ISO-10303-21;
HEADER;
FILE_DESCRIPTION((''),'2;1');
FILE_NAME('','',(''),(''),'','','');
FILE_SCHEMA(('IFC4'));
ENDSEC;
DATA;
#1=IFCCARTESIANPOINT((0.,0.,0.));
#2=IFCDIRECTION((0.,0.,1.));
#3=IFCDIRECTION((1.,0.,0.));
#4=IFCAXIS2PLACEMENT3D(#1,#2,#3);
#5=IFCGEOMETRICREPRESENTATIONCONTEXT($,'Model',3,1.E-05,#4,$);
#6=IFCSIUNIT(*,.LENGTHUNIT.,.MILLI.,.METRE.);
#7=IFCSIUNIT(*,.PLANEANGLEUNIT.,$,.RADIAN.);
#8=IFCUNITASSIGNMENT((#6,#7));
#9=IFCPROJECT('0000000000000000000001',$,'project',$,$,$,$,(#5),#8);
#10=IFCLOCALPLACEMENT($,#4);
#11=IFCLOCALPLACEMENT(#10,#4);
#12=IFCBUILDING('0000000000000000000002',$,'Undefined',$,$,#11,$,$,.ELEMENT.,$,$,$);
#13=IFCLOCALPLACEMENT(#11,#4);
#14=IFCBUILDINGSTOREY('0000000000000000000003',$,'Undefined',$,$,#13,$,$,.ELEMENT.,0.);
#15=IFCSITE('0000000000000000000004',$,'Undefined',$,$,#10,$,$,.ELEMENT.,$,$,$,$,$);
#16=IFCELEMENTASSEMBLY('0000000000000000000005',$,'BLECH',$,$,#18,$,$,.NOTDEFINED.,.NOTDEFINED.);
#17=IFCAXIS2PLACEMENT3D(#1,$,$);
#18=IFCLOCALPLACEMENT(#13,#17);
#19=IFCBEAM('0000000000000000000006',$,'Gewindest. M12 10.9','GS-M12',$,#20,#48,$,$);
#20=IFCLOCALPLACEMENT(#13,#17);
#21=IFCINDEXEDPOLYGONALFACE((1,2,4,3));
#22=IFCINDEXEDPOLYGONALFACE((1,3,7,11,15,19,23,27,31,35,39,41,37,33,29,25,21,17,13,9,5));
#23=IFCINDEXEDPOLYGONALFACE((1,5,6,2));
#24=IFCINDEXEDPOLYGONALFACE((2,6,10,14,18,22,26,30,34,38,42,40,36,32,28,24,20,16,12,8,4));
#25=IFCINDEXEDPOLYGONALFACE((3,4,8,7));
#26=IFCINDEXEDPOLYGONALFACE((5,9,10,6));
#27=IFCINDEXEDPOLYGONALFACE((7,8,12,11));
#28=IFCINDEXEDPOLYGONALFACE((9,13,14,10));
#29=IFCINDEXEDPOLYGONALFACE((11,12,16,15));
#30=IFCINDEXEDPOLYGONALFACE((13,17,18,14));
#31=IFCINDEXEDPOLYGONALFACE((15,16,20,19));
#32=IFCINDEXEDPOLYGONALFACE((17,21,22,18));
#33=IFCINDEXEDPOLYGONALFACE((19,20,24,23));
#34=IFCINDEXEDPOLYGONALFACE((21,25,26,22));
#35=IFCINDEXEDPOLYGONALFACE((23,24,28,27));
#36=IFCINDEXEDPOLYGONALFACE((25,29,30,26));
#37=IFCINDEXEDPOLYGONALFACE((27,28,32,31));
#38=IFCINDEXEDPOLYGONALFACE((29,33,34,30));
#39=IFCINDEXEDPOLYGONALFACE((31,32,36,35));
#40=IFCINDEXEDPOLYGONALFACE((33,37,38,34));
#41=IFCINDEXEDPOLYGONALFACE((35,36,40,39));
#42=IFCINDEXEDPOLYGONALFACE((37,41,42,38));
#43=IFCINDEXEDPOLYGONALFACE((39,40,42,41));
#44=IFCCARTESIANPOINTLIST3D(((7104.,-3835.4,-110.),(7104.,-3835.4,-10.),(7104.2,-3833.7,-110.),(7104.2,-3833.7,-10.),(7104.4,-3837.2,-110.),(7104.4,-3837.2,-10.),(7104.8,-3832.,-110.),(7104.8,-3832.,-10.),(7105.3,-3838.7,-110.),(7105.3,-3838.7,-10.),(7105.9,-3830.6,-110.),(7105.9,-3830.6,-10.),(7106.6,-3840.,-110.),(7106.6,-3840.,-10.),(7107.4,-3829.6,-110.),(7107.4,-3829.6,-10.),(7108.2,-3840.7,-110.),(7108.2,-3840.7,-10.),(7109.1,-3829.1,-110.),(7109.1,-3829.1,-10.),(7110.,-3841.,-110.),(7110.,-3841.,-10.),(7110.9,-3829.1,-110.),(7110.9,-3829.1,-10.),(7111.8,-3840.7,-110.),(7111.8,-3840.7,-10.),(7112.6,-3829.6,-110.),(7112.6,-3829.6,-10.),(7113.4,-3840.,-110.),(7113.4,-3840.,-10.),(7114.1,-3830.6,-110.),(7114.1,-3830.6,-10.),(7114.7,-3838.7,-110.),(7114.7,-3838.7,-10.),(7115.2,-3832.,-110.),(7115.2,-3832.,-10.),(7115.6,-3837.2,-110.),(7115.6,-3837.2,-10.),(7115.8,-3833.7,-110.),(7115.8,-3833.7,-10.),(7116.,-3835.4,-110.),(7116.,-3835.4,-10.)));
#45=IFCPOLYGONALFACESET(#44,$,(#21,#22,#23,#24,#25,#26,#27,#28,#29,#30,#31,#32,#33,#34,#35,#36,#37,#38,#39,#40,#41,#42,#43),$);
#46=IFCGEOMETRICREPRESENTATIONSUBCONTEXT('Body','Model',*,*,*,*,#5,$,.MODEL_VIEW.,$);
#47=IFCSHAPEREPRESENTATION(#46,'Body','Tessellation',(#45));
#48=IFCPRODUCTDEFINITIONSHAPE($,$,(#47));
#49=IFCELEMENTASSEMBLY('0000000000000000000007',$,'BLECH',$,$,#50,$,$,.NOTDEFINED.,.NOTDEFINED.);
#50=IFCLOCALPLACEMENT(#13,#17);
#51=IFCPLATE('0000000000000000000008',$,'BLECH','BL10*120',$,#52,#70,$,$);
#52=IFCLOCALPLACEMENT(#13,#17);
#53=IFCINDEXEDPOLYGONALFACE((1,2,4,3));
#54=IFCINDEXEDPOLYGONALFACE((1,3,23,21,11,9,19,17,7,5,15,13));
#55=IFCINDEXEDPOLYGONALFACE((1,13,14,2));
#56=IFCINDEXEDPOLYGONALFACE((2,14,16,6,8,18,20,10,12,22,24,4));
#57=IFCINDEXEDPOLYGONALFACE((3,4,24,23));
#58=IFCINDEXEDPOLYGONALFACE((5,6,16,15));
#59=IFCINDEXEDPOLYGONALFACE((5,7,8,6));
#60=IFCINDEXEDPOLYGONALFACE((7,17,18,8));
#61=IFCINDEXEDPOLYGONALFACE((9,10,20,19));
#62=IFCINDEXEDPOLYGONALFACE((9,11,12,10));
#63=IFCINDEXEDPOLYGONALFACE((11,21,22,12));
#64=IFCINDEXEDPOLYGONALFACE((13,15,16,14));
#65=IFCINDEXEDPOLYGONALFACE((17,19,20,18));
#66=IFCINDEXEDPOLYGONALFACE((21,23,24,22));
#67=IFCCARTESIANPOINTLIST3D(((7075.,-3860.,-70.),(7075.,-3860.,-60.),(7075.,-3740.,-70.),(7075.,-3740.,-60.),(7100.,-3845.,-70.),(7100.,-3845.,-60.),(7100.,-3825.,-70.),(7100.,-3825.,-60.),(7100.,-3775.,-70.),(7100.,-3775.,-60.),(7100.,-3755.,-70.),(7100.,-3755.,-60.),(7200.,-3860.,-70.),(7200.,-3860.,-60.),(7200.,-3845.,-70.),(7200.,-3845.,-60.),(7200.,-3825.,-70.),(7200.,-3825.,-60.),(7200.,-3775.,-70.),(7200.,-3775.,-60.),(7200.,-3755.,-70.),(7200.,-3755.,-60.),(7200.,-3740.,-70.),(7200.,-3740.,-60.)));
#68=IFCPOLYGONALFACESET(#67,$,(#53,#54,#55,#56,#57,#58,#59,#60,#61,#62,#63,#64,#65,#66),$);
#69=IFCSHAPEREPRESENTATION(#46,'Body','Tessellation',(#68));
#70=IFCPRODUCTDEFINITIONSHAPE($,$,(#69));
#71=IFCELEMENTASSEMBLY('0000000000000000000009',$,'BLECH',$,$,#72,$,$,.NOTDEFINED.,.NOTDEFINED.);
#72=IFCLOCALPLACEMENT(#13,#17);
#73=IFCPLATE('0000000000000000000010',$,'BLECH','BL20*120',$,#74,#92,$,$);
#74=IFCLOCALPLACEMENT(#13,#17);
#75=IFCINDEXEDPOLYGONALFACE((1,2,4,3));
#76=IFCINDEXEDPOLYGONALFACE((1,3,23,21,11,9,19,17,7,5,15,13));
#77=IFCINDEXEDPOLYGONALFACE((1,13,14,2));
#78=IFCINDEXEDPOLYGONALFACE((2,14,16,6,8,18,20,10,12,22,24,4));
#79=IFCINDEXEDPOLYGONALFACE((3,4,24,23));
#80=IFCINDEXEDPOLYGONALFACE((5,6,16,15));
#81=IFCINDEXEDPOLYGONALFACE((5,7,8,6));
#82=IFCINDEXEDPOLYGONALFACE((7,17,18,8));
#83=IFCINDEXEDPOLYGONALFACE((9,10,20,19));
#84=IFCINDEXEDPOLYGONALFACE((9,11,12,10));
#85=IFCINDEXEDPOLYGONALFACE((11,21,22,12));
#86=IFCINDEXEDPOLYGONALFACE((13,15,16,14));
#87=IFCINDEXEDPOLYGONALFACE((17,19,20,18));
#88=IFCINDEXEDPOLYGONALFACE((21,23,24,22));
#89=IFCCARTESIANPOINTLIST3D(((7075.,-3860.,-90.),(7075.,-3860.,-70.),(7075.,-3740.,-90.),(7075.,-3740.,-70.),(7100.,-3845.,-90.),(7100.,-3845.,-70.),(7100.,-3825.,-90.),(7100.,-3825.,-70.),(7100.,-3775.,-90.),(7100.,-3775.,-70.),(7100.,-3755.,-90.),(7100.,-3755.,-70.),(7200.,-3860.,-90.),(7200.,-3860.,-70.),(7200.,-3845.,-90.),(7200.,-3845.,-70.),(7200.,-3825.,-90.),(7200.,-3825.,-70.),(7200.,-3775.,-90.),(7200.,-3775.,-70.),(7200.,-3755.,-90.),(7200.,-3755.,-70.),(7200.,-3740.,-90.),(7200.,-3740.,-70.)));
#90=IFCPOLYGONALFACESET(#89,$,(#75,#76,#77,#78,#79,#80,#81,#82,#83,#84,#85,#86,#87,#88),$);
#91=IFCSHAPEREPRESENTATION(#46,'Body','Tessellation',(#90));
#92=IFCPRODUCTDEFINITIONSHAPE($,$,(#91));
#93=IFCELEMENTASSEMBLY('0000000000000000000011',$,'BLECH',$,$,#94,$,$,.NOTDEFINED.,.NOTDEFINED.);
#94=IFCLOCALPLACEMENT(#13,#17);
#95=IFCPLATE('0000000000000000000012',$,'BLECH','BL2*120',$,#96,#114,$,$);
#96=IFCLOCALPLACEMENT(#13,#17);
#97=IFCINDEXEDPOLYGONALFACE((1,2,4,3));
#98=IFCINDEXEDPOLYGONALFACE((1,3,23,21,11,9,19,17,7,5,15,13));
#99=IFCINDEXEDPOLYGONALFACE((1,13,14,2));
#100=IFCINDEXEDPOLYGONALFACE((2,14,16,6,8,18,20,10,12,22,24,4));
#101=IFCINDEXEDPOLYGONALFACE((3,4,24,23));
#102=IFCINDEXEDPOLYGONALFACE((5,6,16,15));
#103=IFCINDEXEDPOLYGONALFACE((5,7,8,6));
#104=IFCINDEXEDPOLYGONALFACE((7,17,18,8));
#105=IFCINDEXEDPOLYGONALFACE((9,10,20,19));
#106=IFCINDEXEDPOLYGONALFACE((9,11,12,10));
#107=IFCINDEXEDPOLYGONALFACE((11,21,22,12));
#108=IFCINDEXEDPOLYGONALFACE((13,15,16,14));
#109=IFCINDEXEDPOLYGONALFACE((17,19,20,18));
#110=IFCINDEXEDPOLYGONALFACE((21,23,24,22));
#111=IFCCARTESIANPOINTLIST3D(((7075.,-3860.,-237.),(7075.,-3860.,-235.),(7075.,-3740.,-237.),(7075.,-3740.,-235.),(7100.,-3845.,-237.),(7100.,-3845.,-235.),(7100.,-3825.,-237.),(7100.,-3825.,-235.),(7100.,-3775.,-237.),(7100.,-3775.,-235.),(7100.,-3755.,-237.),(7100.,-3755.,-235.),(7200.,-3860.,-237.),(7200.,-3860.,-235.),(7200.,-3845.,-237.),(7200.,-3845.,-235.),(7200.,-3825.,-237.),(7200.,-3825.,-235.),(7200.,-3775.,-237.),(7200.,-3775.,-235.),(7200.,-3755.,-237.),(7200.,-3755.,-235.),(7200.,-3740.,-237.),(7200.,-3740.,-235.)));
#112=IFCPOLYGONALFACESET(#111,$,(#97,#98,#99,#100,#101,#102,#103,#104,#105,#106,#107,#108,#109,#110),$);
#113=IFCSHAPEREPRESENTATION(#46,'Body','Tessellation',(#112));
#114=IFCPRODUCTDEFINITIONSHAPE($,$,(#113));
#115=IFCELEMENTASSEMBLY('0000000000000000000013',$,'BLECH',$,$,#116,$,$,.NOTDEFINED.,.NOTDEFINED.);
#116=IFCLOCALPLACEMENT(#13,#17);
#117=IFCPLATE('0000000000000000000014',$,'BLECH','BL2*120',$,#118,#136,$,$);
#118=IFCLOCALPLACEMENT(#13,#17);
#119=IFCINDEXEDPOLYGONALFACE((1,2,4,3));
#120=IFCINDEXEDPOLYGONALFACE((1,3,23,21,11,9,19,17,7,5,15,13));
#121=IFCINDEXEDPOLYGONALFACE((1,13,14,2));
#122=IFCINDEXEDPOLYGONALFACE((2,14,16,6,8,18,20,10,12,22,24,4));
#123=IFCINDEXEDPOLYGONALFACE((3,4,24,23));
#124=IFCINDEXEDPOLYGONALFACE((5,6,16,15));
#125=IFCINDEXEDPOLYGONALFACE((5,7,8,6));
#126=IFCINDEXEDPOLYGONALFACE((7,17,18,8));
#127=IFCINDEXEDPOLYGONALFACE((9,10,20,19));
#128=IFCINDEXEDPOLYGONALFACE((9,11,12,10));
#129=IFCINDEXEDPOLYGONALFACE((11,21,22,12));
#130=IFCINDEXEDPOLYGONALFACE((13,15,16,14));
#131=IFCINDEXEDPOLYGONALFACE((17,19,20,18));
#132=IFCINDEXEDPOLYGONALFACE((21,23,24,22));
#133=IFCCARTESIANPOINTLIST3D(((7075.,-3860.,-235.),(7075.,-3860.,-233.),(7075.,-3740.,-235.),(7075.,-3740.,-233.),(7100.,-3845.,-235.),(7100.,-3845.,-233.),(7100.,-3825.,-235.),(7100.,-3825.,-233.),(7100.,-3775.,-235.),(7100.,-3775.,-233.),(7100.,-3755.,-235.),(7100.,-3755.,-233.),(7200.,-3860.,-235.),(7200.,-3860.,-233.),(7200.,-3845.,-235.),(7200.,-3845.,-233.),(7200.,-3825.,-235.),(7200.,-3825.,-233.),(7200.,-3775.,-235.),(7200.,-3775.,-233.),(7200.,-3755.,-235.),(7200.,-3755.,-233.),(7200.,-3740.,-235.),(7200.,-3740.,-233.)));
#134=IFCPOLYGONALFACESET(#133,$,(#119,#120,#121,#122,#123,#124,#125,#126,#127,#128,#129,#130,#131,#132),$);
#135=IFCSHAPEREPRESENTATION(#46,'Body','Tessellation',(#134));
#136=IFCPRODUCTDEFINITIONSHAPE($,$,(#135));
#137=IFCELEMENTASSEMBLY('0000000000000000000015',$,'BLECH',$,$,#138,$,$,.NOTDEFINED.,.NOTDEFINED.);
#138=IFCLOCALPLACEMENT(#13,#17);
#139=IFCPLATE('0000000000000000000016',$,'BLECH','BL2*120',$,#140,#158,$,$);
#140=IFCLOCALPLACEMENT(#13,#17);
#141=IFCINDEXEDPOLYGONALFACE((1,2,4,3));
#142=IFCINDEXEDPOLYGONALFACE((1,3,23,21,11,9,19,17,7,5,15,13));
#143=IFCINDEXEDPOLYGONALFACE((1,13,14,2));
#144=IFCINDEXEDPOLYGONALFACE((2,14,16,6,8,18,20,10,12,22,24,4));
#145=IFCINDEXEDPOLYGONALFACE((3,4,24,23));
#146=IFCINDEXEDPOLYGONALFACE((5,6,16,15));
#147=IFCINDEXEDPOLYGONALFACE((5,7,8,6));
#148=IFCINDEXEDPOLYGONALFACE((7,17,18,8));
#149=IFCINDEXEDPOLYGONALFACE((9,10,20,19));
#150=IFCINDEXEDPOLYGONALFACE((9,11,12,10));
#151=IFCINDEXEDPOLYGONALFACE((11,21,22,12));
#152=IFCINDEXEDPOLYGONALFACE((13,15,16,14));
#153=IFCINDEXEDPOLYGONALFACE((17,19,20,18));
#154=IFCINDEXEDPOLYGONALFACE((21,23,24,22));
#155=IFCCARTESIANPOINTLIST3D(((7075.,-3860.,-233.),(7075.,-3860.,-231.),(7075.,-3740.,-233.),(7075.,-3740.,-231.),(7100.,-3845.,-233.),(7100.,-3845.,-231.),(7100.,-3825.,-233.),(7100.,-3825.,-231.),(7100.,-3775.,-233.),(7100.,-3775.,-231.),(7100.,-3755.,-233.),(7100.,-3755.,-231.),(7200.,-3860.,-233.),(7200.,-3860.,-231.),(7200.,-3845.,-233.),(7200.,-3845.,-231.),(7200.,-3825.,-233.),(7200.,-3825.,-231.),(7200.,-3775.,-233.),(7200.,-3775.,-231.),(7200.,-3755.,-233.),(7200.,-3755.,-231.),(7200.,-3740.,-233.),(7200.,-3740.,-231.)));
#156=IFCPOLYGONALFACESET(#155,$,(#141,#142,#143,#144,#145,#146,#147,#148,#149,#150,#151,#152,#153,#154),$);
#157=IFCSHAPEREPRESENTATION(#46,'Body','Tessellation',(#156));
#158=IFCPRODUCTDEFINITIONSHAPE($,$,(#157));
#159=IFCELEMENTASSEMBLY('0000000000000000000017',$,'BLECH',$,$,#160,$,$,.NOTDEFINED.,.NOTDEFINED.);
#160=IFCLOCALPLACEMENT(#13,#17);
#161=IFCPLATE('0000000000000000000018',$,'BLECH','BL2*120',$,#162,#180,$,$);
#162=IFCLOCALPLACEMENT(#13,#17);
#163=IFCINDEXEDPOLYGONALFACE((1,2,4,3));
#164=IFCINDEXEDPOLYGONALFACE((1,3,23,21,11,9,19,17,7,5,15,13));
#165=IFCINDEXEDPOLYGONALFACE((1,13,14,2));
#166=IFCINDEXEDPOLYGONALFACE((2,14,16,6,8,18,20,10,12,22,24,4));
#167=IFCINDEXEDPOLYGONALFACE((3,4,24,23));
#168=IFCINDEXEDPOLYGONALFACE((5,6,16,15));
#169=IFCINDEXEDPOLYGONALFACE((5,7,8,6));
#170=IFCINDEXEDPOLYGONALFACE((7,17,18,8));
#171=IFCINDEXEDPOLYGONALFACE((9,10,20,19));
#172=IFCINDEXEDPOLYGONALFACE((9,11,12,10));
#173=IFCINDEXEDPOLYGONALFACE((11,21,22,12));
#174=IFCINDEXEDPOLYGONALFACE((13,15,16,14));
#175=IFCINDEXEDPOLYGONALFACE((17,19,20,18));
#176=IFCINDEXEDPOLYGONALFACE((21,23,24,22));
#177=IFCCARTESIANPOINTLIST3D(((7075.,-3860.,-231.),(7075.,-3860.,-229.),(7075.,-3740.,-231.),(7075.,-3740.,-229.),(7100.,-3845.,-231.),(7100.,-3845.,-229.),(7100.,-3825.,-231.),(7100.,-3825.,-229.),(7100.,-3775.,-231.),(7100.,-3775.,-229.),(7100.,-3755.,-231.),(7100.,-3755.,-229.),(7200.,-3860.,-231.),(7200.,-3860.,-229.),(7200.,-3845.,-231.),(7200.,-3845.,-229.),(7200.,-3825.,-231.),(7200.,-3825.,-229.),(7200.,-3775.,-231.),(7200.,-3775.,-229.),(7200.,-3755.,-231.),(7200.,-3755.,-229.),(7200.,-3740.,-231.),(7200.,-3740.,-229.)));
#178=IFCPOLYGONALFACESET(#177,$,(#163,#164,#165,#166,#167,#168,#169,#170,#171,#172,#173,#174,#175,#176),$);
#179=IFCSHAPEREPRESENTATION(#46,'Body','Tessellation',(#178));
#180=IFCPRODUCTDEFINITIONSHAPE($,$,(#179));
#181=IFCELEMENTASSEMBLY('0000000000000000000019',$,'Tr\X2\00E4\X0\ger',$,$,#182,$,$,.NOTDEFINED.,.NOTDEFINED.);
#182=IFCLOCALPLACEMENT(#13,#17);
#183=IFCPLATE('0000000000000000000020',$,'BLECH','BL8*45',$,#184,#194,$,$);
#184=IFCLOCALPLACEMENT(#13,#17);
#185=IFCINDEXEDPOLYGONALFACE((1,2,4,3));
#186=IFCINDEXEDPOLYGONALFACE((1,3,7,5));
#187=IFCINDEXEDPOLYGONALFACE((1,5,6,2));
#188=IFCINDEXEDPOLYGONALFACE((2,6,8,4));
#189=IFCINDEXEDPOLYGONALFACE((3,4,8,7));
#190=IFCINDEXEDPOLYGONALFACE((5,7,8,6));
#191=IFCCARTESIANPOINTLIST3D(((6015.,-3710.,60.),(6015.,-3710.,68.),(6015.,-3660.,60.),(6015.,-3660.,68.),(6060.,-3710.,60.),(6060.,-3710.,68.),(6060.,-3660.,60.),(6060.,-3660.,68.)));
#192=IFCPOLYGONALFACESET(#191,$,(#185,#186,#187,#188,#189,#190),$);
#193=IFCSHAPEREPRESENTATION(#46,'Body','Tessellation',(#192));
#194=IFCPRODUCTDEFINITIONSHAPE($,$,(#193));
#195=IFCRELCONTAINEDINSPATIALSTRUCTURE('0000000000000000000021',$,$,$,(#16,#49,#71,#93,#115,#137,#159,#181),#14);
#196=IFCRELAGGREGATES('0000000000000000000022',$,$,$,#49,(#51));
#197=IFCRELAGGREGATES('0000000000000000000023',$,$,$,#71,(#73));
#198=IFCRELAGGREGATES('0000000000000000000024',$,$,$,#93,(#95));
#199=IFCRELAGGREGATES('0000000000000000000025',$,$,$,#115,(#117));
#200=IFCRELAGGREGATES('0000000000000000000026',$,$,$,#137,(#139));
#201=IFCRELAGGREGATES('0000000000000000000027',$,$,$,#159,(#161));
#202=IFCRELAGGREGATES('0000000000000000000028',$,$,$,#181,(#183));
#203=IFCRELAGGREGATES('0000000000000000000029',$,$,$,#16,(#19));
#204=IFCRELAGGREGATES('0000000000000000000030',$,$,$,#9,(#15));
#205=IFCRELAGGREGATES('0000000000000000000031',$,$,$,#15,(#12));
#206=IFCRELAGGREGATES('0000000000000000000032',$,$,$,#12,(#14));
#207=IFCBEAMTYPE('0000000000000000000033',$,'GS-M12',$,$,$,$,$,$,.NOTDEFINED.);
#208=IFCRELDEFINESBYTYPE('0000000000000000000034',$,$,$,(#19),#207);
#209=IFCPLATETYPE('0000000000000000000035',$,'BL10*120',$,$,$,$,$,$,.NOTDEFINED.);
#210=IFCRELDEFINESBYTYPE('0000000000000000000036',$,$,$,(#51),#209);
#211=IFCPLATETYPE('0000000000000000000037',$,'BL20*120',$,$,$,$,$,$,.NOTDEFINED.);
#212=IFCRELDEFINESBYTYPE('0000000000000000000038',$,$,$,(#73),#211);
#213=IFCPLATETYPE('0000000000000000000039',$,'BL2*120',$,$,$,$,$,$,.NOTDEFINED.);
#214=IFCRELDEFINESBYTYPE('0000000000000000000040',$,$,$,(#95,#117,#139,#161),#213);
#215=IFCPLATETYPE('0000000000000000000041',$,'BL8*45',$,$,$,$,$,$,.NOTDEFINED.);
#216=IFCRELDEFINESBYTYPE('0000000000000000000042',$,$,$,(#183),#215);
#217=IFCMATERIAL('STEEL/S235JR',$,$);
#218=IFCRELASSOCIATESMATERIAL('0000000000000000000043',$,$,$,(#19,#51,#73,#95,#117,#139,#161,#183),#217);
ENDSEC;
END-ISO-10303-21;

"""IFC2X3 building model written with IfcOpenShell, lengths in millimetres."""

from ifc_helpers import new_model, si_unit, frame, origin_with_axes, origin_2d_with_axis, place, context, subcontext, project, spatial, polyline, circle, outline, extrude, material, type_object, element, aggregate, save


model = new_model("IFC2X3")

# Units and contexts
model_context = context("Model", 3, precision=1e-05, world=origin_with_axes())
body_context = subcontext(model_context, "Body", "Model", "MODEL_VIEW")
ifc_project = project(units=[si_unit("LENGTHUNIT", "METRE", prefix="MILLI"), si_unit("PLANEANGLEUNIT", "RADIAN")], contexts=[model_context])

# Site, building, storey
site_placement = place(None, origin_with_axes())
site = spatial("IfcSite", under=ifc_project, at=site_placement, Name="Undefined", CompositionType="ELEMENT")
building_placement = place(site_placement, origin_with_axes())
building = spatial("IfcBuilding", under=site, at=building_placement, Name="Undefined", CompositionType="ELEMENT")
storey_placement = place(building_placement, origin_with_axes())
storey = spatial("IfcBuildingStorey", under=building, at=storey_placement, Name="Undefined", CompositionType="ELEMENT", Elevation=0.0)

# Element assembly, beam
assembly_1_placement = place(storey_placement, origin_with_axes())
assembly_1 = element("IfcElementAssembly", 1, at=assembly_1_placement, inside=storey, Name="BLECH", AssemblyPlace="NOTDEFINED", PredefinedType="NOTDEFINED")
ifc_material_1 = material(Name="STEEL/S235JR")
beam_type_1 = type_object("IfcBeamType", Name="GS-M12", PredefinedType="NOTDEFINED")
beam_1_placement = place(assembly_1_placement, frame((7110.0, -3835.0, -10.0), z_axis=(1.0, 0.0, 0.0), x_axis=(0.0, 0.0, -1.0)))
beam_1 = element("IfcBeam", 2, at=beam_1_placement, type_object=beam_type_1, material=ifc_material_1, Name="Gewindest. M12 10.9", Description="GS-M12", context=body_context, shape_type="SweptSolid", body=[
    extrude(circle(Radius=6.0, at=origin_2d_with_axis()), frame((100.0, 0.0, 0.0), z_axis=(-1.0, 0.0, 0.0), x_axis=(0.0, -1.0, 0.0)), (0.0, 0.0, 1.0), 100.0),
])

# Element assemblies, plates
assembly_2_placement = place(storey_placement, origin_with_axes())
assembly_2 = element("IfcElementAssembly", 3, at=assembly_2_placement, inside=storey, Name="BLECH", AssemblyPlace="NOTDEFINED", PredefinedType="NOTDEFINED")
plate_type_1 = type_object("IfcPlateType", Name="BL10*120", PredefinedType="NOTDEFINED")
plate_1_placement = place(assembly_2_placement, frame((7075.0, -3740.0, -65.0), z_axis=(0.0, 0.0, -1.0), x_axis=(1.0, 0.0, 0.0)))
plate_1 = element("IfcPlate", 4, at=plate_1_placement, type_object=plate_type_1, material=ifc_material_1, Name="BLECH", Description="BL10*120", context=body_context, shape_type="SweptSolid", body=[
    extrude(outline(polyline([(0.0, 0.0), (125.0, 0.0), (125.0, 15.0), (25.0, 15.0), (25.0, 35.0), (125.0, 35.0), (125.0, 85.0), (25.0, 85.0), (25.0, 105.0), (125.0, 105.0), (125.0, 120.0), (0.0, 120.0), (0.0, 0.0)])), frame((0.0, 0.0, -5.0), z_axis=(0.0, 0.0, 1.0), x_axis=(1.0, 0.0, 0.0)), (0.0, 0.0, 1.0), 10.0),
])
aggregate(assembly_2, [plate_1])
assembly_3_placement = place(storey_placement, origin_with_axes())
assembly_3 = element("IfcElementAssembly", 5, at=assembly_3_placement, inside=storey, Name="BLECH", AssemblyPlace="NOTDEFINED", PredefinedType="NOTDEFINED")
plate_type_2 = type_object("IfcPlateType", Name="BL20*120", PredefinedType="NOTDEFINED")
plate_2_placement = place(assembly_3_placement, frame((7075.0, -3740.0, -80.0), z_axis=(0.0, 0.0, -1.0), x_axis=(1.0, 0.0, 0.0)))
plate_2 = element("IfcPlate", 6, at=plate_2_placement, type_object=plate_type_2, material=ifc_material_1, Name="BLECH", Description="BL20*120", context=body_context, shape_type="SweptSolid", body=[
    extrude(outline(polyline([(0.0, 0.0), (125.0, 0.0), (125.0, 15.0), (25.0, 15.0), (25.0, 35.0), (125.0, 35.0), (125.0, 85.0), (25.0, 85.0), (25.0, 105.0), (125.0, 105.0), (125.0, 120.0), (0.0, 120.0), (0.0, 0.0)])), frame((0.0, 0.0, -10.0), z_axis=(0.0, 0.0, 1.0), x_axis=(1.0, 0.0, 0.0)), (0.0, 0.0, 1.0), 20.0),
])
aggregate(assembly_3, [plate_2])
assembly_4_placement = place(storey_placement, origin_with_axes())
assembly_4 = element("IfcElementAssembly", 7, at=assembly_4_placement, inside=storey, Name="BLECH", AssemblyPlace="NOTDEFINED", PredefinedType="NOTDEFINED")
plate_type_3 = type_object("IfcPlateType", Name="BL2*120", PredefinedType="NOTDEFINED")
plate_3_placement = place(assembly_4_placement, frame((7075.0, -3740.0, -236.0), z_axis=(0.0, 0.0, -1.0), x_axis=(1.0, 0.0, 0.0)))
plate_3 = element("IfcPlate", 8, at=plate_3_placement, type_object=plate_type_3, material=ifc_material_1, Name="BLECH", Description="BL2*120", context=body_context, shape_type="SweptSolid", body=[
    extrude(outline(polyline([(0.0, 0.0), (125.0, 0.0), (125.0, 15.0), (25.0, 15.0), (25.0, 35.0), (125.0, 35.0), (125.0, 85.0), (25.0, 85.0), (25.0, 105.0), (125.0, 105.0), (125.0, 120.0), (0.0, 120.0), (0.0, 0.0)])), frame((0.0, 0.0, -1.0), z_axis=(0.0, 0.0, 1.0), x_axis=(1.0, 0.0, 0.0)), (0.0, 0.0, 1.0), 2.0),
])
aggregate(assembly_4, [plate_3])
assembly_5_placement = place(storey_placement, origin_with_axes())
assembly_5 = element("IfcElementAssembly", 9, at=assembly_5_placement, inside=storey, Name="BLECH", AssemblyPlace="NOTDEFINED", PredefinedType="NOTDEFINED")
plate_4_placement = place(assembly_5_placement, frame((7075.0, -3740.0, -234.0), z_axis=(0.0, 0.0, -1.0), x_axis=(1.0, 0.0, 0.0)))
plate_4 = element("IfcPlate", 10, at=plate_4_placement, type_object=plate_type_3, material=ifc_material_1, Name="BLECH", Description="BL2*120", context=body_context, shape_type="SweptSolid", body=[
    extrude(outline(polyline([(0.0, 0.0), (125.0, 0.0), (125.0, 15.0), (25.0, 15.0), (25.0, 35.0), (125.0, 35.0), (125.0, 85.0), (25.0, 85.0), (25.0, 105.0), (125.0, 105.0), (125.0, 120.0), (0.0, 120.0), (0.0, 0.0)])), frame((0.0, 0.0, -1.0), z_axis=(0.0, 0.0, 1.0), x_axis=(1.0, 0.0, 0.0)), (0.0, 0.0, 1.0), 2.0),
])
aggregate(assembly_5, [plate_4])
assembly_6_placement = place(storey_placement, origin_with_axes())
assembly_6 = element("IfcElementAssembly", 11, at=assembly_6_placement, inside=storey, Name="BLECH", AssemblyPlace="NOTDEFINED", PredefinedType="NOTDEFINED")
plate_5_placement = place(assembly_6_placement, frame((7075.0, -3740.0, -232.0), z_axis=(0.0, 0.0, -1.0), x_axis=(1.0, 0.0, 0.0)))
plate_5 = element("IfcPlate", 12, at=plate_5_placement, type_object=plate_type_3, material=ifc_material_1, Name="BLECH", Description="BL2*120", context=body_context, shape_type="SweptSolid", body=[
    extrude(outline(polyline([(0.0, 0.0), (125.0, 0.0), (125.0, 15.0), (25.0, 15.0), (25.0, 35.0), (125.0, 35.0), (125.0, 85.0), (25.0, 85.0), (25.0, 105.0), (125.0, 105.0), (125.0, 120.0), (0.0, 120.0), (0.0, 0.0)])), frame((0.0, 0.0, -1.0), z_axis=(0.0, 0.0, 1.0), x_axis=(1.0, 0.0, 0.0)), (0.0, 0.0, 1.0), 2.0),
])
aggregate(assembly_6, [plate_5])
assembly_7_placement = place(storey_placement, origin_with_axes())
assembly_7 = element("IfcElementAssembly", 13, at=assembly_7_placement, inside=storey, Name="BLECH", AssemblyPlace="NOTDEFINED", PredefinedType="NOTDEFINED")
plate_6_placement = place(assembly_7_placement, frame((7075.0, -3740.0, -230.0), z_axis=(0.0, 0.0, -1.0), x_axis=(1.0, 0.0, 0.0)))
plate_6 = element("IfcPlate", 14, at=plate_6_placement, type_object=plate_type_3, material=ifc_material_1, Name="BLECH", Description="BL2*120", context=body_context, shape_type="SweptSolid", body=[
    extrude(outline(polyline([(0.0, 0.0), (125.0, 0.0), (125.0, 15.0), (25.0, 15.0), (25.0, 35.0), (125.0, 35.0), (125.0, 85.0), (25.0, 85.0), (25.0, 105.0), (125.0, 105.0), (125.0, 120.0), (0.0, 120.0), (0.0, 0.0)])), frame((0.0, 0.0, -1.0), z_axis=(0.0, 0.0, 1.0), x_axis=(1.0, 0.0, 0.0)), (0.0, 0.0, 1.0), 2.0),
])
aggregate(assembly_7, [plate_6])

# Element assembly, plate
assembly_8_placement = place(storey_placement, origin_with_axes())
assembly_8 = element("IfcElementAssembly", 15, at=assembly_8_placement, inside=storey, Name="Träger", AssemblyPlace="NOTDEFINED", PredefinedType="NOTDEFINED")
plate_type_4 = type_object("IfcPlateType", Name="BL8*45", PredefinedType="NOTDEFINED")
plate_7_placement = place(assembly_8_placement, frame((6060.0, -3660.0, 64.0), z_axis=(0.0, 0.0, 1.0), x_axis=(-1.0, 0.0, 0.0)))
plate_7 = element("IfcPlate", 16, at=plate_7_placement, type_object=plate_type_4, material=ifc_material_1, Name="BLECH", Description="BL8*45", context=body_context, shape_type="SweptSolid", body=[
    extrude(outline(polyline([(0.0, 0.0), (45.0, 0.0), (45.0, 50.0), (0.0, 50.0), (0.0, 0.0)])), frame((0.0, 0.0, -4.0), z_axis=(0.0, 0.0, 1.0), x_axis=(1.0, 0.0, 0.0)), (0.0, 0.0, 1.0), 8.0),
])
aggregate(assembly_8, [plate_7])

aggregate(assembly_1, [beam_1])

save(model, "model.ifc")
